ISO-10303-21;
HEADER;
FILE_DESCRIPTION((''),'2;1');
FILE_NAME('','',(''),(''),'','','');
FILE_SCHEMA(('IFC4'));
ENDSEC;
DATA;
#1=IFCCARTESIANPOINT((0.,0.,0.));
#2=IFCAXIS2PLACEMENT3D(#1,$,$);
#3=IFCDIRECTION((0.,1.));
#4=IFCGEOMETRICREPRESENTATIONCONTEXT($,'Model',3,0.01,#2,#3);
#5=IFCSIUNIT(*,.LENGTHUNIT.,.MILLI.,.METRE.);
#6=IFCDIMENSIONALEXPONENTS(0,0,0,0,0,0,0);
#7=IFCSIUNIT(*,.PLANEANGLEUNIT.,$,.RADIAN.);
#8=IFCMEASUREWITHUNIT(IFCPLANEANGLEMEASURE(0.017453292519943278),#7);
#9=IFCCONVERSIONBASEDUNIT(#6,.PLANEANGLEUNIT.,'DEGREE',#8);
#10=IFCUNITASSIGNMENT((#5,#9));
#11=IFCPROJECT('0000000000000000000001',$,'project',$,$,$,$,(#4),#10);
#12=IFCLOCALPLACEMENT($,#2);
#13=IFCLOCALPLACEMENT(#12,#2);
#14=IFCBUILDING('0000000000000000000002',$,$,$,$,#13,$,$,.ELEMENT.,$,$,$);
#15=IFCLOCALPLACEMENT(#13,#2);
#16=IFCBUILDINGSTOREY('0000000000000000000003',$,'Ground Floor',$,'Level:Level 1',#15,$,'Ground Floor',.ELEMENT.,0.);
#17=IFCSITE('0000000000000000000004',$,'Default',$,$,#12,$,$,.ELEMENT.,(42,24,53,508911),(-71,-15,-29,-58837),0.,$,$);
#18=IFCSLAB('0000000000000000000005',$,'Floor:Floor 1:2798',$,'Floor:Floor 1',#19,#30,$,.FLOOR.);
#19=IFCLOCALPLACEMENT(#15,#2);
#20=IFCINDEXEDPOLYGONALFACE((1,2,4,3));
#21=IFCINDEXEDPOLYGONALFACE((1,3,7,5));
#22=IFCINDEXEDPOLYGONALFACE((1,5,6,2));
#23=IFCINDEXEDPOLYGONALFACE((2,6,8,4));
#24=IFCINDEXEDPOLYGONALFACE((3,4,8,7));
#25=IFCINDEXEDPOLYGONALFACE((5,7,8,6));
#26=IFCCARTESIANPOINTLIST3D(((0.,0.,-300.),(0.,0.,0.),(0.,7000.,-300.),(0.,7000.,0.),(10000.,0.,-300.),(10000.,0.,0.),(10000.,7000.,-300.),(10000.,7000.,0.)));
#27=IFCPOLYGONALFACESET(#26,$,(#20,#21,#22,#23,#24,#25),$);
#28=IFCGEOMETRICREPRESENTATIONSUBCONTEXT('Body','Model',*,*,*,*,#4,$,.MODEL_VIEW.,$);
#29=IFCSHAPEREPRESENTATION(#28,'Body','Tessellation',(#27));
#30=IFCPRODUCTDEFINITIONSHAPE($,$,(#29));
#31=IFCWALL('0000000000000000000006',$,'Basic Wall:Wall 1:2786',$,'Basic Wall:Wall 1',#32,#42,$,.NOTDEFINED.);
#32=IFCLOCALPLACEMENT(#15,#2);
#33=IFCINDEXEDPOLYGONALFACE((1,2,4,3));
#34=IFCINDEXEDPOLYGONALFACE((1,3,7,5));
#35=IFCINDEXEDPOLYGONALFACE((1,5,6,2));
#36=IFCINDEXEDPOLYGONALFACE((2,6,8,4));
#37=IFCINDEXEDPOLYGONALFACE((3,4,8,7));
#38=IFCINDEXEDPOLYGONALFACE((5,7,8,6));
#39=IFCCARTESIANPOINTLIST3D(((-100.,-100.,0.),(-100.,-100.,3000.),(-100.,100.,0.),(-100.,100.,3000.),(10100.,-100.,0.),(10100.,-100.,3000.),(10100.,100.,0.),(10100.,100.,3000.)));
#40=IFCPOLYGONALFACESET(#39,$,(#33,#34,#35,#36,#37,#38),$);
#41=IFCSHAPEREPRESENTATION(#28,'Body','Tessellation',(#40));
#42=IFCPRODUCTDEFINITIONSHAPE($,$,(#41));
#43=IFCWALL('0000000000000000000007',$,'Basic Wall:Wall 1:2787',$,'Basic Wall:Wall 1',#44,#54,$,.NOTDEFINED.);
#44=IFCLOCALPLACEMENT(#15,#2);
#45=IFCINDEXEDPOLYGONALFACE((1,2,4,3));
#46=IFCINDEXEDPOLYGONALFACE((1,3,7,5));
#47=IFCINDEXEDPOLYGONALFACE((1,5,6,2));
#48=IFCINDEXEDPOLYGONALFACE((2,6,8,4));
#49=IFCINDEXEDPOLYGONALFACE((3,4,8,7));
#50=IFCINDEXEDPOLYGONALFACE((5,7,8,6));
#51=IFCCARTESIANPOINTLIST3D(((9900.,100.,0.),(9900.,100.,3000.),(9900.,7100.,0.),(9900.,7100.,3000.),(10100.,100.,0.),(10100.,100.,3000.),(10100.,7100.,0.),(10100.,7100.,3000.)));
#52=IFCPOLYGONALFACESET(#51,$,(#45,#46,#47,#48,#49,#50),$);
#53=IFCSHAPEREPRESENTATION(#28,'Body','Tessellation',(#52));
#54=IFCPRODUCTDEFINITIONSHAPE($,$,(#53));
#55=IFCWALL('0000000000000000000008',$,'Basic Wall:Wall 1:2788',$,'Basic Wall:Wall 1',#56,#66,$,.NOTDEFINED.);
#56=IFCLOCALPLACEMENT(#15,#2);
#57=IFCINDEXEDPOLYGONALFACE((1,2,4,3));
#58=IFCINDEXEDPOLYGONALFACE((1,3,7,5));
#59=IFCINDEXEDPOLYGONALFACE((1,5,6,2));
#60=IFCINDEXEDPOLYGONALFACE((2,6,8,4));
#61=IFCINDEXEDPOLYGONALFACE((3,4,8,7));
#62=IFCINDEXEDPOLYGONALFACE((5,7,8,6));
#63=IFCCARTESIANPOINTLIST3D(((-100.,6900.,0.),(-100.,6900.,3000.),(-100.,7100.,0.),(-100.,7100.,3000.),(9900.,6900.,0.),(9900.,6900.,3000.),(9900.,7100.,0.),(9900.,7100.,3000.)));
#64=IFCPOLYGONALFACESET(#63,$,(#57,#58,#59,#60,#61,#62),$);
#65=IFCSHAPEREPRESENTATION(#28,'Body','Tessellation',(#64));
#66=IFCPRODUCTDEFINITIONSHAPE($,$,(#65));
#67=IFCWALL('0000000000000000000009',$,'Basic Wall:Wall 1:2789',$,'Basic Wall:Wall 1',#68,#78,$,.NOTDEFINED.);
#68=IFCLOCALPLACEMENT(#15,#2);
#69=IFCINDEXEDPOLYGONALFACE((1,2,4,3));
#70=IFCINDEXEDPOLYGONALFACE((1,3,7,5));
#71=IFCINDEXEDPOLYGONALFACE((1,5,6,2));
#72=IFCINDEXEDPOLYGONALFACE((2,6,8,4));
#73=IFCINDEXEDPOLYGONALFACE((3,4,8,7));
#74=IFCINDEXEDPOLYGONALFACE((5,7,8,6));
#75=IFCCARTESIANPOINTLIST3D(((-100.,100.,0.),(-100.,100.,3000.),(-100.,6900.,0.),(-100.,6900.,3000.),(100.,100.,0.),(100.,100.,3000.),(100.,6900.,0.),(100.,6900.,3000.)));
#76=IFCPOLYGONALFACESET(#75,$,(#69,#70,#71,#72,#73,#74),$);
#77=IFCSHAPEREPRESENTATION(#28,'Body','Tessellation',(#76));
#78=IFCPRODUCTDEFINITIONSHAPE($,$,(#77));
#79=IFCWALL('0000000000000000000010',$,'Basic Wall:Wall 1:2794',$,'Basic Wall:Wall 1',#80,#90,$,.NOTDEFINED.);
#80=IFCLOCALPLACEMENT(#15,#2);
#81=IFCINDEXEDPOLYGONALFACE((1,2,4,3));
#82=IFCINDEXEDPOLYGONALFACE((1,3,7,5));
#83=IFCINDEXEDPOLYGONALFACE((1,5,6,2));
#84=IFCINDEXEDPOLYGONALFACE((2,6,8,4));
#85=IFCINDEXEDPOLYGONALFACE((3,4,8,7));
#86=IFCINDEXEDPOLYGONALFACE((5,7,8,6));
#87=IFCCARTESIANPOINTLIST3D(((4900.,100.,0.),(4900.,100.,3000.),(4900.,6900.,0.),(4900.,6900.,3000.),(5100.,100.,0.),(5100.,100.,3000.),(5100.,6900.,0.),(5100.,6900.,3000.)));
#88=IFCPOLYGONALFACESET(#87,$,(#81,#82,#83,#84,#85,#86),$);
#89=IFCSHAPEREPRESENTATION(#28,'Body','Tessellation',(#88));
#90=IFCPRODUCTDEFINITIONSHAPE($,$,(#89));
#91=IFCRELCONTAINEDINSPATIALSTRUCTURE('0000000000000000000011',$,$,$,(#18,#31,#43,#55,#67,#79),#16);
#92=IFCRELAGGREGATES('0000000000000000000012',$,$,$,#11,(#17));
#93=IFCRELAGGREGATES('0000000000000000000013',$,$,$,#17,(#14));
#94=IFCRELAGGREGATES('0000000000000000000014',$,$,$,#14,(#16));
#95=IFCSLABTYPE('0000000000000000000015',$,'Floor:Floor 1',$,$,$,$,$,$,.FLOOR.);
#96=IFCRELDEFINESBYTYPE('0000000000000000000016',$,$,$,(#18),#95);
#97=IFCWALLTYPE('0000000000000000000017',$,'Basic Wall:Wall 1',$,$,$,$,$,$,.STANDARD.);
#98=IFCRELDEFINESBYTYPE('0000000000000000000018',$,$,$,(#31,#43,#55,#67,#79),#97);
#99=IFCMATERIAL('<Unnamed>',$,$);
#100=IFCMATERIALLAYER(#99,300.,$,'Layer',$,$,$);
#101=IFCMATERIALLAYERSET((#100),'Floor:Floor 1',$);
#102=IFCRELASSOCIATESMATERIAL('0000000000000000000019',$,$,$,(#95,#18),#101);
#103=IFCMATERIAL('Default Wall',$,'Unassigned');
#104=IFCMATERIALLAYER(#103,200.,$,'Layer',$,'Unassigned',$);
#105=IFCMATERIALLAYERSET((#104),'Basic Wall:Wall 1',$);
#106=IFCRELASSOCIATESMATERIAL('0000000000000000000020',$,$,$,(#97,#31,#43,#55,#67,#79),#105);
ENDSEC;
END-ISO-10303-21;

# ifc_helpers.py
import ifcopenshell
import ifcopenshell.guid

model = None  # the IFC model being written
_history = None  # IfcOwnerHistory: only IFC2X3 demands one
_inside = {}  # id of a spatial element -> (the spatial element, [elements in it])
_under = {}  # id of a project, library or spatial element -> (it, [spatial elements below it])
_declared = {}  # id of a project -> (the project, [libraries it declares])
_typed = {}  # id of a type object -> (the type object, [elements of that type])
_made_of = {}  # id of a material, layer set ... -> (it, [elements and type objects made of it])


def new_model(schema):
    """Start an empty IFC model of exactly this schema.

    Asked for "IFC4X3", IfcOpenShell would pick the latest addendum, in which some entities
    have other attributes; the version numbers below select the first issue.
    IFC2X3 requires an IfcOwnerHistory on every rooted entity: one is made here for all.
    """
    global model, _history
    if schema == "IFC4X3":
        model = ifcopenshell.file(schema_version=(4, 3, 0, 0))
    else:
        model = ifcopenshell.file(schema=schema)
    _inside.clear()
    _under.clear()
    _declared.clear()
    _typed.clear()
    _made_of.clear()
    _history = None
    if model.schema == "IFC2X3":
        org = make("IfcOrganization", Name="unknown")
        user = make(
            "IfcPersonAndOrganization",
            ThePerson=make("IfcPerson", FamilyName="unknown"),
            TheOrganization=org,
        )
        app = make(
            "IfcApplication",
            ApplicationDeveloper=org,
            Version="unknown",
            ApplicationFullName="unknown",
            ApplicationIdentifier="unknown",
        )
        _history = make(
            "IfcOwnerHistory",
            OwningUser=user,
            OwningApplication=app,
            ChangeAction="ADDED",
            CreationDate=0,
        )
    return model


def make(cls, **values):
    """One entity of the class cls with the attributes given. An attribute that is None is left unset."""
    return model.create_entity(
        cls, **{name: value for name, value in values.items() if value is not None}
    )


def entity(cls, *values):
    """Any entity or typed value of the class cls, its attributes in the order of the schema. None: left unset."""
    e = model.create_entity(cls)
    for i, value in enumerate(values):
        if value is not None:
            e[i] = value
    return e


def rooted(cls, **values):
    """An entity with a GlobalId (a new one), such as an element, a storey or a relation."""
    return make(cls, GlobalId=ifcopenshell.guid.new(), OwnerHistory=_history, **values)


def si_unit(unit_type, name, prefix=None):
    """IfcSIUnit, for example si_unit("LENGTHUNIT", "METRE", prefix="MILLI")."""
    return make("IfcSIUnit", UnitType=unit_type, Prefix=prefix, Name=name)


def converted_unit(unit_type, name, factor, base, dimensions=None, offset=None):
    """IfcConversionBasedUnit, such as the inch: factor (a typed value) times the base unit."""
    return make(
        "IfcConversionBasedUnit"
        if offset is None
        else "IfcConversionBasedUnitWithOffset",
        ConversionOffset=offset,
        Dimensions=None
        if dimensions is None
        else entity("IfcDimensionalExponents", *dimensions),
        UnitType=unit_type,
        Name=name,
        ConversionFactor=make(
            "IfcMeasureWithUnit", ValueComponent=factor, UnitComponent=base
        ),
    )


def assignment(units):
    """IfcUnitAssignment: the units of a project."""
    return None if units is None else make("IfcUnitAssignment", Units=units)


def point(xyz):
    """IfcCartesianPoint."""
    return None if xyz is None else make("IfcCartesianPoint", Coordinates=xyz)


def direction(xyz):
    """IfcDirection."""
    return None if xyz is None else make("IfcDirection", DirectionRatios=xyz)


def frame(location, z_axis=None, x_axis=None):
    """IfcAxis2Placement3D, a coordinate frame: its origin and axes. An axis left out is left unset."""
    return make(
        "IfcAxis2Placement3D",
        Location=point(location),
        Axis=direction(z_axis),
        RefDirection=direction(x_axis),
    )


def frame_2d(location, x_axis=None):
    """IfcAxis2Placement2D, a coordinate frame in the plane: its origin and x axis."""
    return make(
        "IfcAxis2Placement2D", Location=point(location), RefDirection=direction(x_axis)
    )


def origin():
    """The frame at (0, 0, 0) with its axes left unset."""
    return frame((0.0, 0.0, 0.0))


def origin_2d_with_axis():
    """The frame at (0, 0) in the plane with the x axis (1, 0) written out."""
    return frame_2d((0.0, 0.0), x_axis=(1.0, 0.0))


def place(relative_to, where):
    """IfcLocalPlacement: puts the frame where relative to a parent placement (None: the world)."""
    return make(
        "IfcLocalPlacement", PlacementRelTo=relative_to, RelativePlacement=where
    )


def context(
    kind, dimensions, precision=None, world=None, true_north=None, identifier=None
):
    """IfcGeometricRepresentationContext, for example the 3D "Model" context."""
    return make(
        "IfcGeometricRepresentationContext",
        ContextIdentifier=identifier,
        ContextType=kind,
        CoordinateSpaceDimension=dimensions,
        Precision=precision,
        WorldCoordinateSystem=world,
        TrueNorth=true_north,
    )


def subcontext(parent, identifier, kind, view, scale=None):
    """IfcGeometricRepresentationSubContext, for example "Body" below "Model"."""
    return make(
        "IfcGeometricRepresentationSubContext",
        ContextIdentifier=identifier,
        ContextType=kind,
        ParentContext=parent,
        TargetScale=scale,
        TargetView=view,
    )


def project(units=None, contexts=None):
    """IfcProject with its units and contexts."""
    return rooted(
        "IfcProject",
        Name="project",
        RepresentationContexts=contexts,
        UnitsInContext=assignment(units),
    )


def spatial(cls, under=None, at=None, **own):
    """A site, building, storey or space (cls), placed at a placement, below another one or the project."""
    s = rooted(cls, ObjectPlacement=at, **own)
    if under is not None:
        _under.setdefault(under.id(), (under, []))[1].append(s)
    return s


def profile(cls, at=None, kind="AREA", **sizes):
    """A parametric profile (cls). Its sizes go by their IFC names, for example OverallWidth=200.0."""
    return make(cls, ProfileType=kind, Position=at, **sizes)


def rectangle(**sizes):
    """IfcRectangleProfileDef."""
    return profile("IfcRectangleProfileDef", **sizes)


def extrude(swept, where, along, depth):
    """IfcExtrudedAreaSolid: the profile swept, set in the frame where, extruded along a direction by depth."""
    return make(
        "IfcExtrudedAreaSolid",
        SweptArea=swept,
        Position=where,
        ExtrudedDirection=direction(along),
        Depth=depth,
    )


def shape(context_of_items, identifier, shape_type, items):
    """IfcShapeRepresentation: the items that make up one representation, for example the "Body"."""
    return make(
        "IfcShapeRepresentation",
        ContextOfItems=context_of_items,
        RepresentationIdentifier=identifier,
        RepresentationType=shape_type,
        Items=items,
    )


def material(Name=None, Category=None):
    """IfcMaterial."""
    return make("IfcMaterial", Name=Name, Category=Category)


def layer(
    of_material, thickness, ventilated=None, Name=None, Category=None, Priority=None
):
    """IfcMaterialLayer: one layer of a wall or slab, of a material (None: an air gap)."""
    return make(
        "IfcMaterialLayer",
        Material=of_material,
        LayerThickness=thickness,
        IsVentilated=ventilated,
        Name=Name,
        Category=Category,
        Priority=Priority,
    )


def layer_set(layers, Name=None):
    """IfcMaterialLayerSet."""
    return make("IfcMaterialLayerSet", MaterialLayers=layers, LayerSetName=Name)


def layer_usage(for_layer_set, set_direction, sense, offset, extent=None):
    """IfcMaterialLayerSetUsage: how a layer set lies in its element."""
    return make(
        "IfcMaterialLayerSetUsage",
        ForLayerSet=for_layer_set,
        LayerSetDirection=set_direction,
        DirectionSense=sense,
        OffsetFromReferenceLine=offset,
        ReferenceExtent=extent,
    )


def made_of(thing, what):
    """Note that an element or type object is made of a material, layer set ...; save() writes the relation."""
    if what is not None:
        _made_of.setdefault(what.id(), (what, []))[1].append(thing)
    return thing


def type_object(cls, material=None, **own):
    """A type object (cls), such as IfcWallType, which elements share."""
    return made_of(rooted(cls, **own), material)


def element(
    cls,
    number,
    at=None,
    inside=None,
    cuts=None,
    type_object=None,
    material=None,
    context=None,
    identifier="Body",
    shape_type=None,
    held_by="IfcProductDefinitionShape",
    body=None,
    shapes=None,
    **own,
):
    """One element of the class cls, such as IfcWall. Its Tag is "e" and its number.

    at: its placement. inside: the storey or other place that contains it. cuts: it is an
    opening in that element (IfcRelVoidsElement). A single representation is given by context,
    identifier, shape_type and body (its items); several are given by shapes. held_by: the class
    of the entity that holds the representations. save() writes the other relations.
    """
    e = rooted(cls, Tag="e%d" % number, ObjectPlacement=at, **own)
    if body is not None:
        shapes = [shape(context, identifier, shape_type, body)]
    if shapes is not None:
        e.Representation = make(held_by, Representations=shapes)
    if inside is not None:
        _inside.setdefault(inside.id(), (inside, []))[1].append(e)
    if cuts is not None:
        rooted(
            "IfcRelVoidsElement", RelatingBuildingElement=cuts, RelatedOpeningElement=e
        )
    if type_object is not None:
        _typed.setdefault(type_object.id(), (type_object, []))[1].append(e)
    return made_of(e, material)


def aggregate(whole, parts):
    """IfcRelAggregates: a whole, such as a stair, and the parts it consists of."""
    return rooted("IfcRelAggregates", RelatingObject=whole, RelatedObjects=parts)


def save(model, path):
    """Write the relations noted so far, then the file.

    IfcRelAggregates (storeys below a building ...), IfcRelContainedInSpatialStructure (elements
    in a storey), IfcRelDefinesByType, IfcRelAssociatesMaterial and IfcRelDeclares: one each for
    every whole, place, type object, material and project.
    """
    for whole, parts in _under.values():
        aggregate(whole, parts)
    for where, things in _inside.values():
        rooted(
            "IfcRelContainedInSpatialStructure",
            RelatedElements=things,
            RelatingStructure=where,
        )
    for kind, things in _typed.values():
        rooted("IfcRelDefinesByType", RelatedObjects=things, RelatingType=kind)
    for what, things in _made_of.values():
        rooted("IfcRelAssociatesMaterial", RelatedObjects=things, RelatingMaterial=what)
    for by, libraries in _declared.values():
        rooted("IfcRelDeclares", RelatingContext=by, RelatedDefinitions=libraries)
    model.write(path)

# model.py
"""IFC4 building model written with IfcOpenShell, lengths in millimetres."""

from ifc_helpers import new_model, entity, si_unit, converted_unit, direction, frame, frame_2d, origin, origin_2d_with_axis, place, context, subcontext, project, spatial, rectangle, extrude, material, layer, layer_set, layer_usage, type_object, element, save


model = new_model("IFC4")

# Units and contexts
model_context = context("Model", 3, precision=0.01, world=origin(), true_north=direction((0.0, 1.0)))
body_context = subcontext(model_context, "Body", "Model", "MODEL_VIEW")
ifc_project = project(units=[si_unit("LENGTHUNIT", "METRE", prefix="MILLI"), converted_unit("PLANEANGLEUNIT", "DEGREE", entity("IfcPlaneAngleMeasure", 0.017453292519943278), si_unit("PLANEANGLEUNIT", "RADIAN"), dimensions=[0, 0, 0, 0, 0, 0, 0])], contexts=[model_context])

# Site, building, storey
site_placement = place(None, origin())
site = spatial("IfcSite", under=ifc_project, at=site_placement, Name="Default", CompositionType="ELEMENT", RefLatitude=(42, 24, 53, 508911), RefLongitude=(-71, -15, -29, -58837), RefElevation=0.0)
building_placement = place(site_placement, origin())
building = spatial("IfcBuilding", under=site, at=building_placement, CompositionType="ELEMENT")
storey_placement = place(building_placement, origin())
storey = spatial("IfcBuildingStorey", under=building, at=storey_placement, Name="Ground Floor", ObjectType="Level:Level 1", LongName="Ground Floor", CompositionType="ELEMENT", Elevation=0.0)

# Slab
ifc_material_1 = material(Name="<Unnamed>")
ifc_layer_1 = layer(ifc_material_1, 300.0, Name="Layer")
ifc_layer_set_1 = layer_set([ifc_layer_1], Name="Floor:Floor 1")
ifc_layer_usage_1 = layer_usage(ifc_layer_set_1, "AXIS3", "POSITIVE", 0.0)
slab_type = type_object("IfcSlabType", Name="Floor:Floor 1", PredefinedType="FLOOR", material=ifc_layer_set_1)
slab_placement = place(storey_placement, origin())
element("IfcSlab", 1, at=slab_placement, inside=storey, type_object=slab_type, material=ifc_layer_usage_1, Name="Floor:Floor 1:2798", ObjectType="Floor:Floor 1", PredefinedType="FLOOR", context=body_context, shape_type="SweptSolid", body=[
    extrude(rectangle(XDim=7000.0, YDim=10000.0, at=origin_2d_with_axis()), frame((5000.0, 3500.0, 0.0), z_axis=(0.0, 0.0, -1.0), x_axis=(0.0, 1.0, 0.0)), (0.0, 0.0, 1.0), 300.0),
])

# Walls
ifc_material_2 = material(Name="Default Wall", Category="Unassigned")
ifc_layer_2 = layer(ifc_material_2, 200.0, Name="Layer", Category="Unassigned")
ifc_layer_set_2 = layer_set([ifc_layer_2], Name="Basic Wall:Wall 1")
ifc_layer_usage_2 = layer_usage(ifc_layer_set_2, "AXIS2", "NEGATIVE", 100.0)
wall_type = type_object("IfcWallType", Name="Basic Wall:Wall 1", PredefinedType="STANDARD", material=ifc_layer_set_2)
wall_1_placement = place(storey_placement, frame((-100.0, 0.0, 0.0)))
element("IfcWall", 2, at=wall_1_placement, inside=storey, type_object=wall_type, material=ifc_layer_usage_2, Name="Basic Wall:Wall 1:2786", ObjectType="Basic Wall:Wall 1", PredefinedType="NOTDEFINED", context=body_context, shape_type="SweptSolid", body=[
    extrude(rectangle(XDim=10200.0, YDim=200.0, at=frame_2d((5100.0, 0.0), x_axis=(-1.0, 0.0))), origin(), (0.0, 0.0, 1.0), 3000.0),
])
ifc_layer_usage_3 = layer_usage(ifc_layer_set_2, "AXIS2", "NEGATIVE", 100.0)
wall_2_placement = place(storey_placement, frame((10000.0, 100.0, 0.0), z_axis=(0.0, 0.0, 1.0), x_axis=(0.0, 1.0, 0.0)))
element("IfcWall", 3, at=wall_2_placement, inside=storey, type_object=wall_type, material=ifc_layer_usage_3, Name="Basic Wall:Wall 1:2787", ObjectType="Basic Wall:Wall 1", PredefinedType="NOTDEFINED", context=body_context, shape_type="SweptSolid", body=[
    extrude(rectangle(XDim=7000.0, YDim=200.0, at=frame_2d((3500.0, 0.0), x_axis=(-1.0, 0.0))), origin(), (0.0, 0.0, 1.0), 3000.0),
])
ifc_layer_usage_4 = layer_usage(ifc_layer_set_2, "AXIS2", "NEGATIVE", 100.0)
wall_3_placement = place(storey_placement, frame((9900.0, 7000.0, 0.0), z_axis=(0.0, 0.0, 1.0), x_axis=(-1.0, 0.0, 0.0)))
element("IfcWall", 4, at=wall_3_placement, inside=storey, type_object=wall_type, material=ifc_layer_usage_4, Name="Basic Wall:Wall 1:2788", ObjectType="Basic Wall:Wall 1", PredefinedType="NOTDEFINED", context=body_context, shape_type="SweptSolid", body=[
    extrude(rectangle(XDim=10000.0, YDim=200.0, at=frame_2d((5000.0, 0.0), x_axis=(-1.0, 0.0))), origin(), (0.0, 0.0, 1.0), 3000.0),
])
ifc_layer_usage_5 = layer_usage(ifc_layer_set_2, "AXIS2", "NEGATIVE", 100.0)
wall_4_placement = place(storey_placement, frame((0.0, 6900.0, 0.0), z_axis=(0.0, 0.0, 1.0), x_axis=(0.0, -1.0, 0.0)))
element("IfcWall", 5, at=wall_4_placement, inside=storey, type_object=wall_type, material=ifc_layer_usage_5, Name="Basic Wall:Wall 1:2789", ObjectType="Basic Wall:Wall 1", PredefinedType="NOTDEFINED", context=body_context, shape_type="SweptSolid", body=[
    extrude(rectangle(XDim=6800.0, YDim=200.0, at=frame_2d((3400.0, 0.0), x_axis=(-1.0, 0.0))), origin(), (0.0, 0.0, 1.0), 3000.0),
])
ifc_layer_usage_6 = layer_usage(ifc_layer_set_2, "AXIS2", "NEGATIVE", 100.0)
wall_5_placement = place(storey_placement, frame((5000.0, 100.0, 0.0), z_axis=(0.0, 0.0, 1.0), x_axis=(0.0, 1.0, 0.0)))
element("IfcWall", 6, at=wall_5_placement, inside=storey, type_object=wall_type, material=ifc_layer_usage_6, Name="Basic Wall:Wall 1:2794", ObjectType="Basic Wall:Wall 1", PredefinedType="NOTDEFINED", context=body_context, shape_type="SweptSolid", body=[
    extrude(rectangle(XDim=6800.0, YDim=200.0, at=frame_2d((3400.0, 0.0), x_axis=(-1.0, 0.0))), origin(), (0.0, 0.0, 1.0), 3000.0),
])

save(model, "model.ifc")
